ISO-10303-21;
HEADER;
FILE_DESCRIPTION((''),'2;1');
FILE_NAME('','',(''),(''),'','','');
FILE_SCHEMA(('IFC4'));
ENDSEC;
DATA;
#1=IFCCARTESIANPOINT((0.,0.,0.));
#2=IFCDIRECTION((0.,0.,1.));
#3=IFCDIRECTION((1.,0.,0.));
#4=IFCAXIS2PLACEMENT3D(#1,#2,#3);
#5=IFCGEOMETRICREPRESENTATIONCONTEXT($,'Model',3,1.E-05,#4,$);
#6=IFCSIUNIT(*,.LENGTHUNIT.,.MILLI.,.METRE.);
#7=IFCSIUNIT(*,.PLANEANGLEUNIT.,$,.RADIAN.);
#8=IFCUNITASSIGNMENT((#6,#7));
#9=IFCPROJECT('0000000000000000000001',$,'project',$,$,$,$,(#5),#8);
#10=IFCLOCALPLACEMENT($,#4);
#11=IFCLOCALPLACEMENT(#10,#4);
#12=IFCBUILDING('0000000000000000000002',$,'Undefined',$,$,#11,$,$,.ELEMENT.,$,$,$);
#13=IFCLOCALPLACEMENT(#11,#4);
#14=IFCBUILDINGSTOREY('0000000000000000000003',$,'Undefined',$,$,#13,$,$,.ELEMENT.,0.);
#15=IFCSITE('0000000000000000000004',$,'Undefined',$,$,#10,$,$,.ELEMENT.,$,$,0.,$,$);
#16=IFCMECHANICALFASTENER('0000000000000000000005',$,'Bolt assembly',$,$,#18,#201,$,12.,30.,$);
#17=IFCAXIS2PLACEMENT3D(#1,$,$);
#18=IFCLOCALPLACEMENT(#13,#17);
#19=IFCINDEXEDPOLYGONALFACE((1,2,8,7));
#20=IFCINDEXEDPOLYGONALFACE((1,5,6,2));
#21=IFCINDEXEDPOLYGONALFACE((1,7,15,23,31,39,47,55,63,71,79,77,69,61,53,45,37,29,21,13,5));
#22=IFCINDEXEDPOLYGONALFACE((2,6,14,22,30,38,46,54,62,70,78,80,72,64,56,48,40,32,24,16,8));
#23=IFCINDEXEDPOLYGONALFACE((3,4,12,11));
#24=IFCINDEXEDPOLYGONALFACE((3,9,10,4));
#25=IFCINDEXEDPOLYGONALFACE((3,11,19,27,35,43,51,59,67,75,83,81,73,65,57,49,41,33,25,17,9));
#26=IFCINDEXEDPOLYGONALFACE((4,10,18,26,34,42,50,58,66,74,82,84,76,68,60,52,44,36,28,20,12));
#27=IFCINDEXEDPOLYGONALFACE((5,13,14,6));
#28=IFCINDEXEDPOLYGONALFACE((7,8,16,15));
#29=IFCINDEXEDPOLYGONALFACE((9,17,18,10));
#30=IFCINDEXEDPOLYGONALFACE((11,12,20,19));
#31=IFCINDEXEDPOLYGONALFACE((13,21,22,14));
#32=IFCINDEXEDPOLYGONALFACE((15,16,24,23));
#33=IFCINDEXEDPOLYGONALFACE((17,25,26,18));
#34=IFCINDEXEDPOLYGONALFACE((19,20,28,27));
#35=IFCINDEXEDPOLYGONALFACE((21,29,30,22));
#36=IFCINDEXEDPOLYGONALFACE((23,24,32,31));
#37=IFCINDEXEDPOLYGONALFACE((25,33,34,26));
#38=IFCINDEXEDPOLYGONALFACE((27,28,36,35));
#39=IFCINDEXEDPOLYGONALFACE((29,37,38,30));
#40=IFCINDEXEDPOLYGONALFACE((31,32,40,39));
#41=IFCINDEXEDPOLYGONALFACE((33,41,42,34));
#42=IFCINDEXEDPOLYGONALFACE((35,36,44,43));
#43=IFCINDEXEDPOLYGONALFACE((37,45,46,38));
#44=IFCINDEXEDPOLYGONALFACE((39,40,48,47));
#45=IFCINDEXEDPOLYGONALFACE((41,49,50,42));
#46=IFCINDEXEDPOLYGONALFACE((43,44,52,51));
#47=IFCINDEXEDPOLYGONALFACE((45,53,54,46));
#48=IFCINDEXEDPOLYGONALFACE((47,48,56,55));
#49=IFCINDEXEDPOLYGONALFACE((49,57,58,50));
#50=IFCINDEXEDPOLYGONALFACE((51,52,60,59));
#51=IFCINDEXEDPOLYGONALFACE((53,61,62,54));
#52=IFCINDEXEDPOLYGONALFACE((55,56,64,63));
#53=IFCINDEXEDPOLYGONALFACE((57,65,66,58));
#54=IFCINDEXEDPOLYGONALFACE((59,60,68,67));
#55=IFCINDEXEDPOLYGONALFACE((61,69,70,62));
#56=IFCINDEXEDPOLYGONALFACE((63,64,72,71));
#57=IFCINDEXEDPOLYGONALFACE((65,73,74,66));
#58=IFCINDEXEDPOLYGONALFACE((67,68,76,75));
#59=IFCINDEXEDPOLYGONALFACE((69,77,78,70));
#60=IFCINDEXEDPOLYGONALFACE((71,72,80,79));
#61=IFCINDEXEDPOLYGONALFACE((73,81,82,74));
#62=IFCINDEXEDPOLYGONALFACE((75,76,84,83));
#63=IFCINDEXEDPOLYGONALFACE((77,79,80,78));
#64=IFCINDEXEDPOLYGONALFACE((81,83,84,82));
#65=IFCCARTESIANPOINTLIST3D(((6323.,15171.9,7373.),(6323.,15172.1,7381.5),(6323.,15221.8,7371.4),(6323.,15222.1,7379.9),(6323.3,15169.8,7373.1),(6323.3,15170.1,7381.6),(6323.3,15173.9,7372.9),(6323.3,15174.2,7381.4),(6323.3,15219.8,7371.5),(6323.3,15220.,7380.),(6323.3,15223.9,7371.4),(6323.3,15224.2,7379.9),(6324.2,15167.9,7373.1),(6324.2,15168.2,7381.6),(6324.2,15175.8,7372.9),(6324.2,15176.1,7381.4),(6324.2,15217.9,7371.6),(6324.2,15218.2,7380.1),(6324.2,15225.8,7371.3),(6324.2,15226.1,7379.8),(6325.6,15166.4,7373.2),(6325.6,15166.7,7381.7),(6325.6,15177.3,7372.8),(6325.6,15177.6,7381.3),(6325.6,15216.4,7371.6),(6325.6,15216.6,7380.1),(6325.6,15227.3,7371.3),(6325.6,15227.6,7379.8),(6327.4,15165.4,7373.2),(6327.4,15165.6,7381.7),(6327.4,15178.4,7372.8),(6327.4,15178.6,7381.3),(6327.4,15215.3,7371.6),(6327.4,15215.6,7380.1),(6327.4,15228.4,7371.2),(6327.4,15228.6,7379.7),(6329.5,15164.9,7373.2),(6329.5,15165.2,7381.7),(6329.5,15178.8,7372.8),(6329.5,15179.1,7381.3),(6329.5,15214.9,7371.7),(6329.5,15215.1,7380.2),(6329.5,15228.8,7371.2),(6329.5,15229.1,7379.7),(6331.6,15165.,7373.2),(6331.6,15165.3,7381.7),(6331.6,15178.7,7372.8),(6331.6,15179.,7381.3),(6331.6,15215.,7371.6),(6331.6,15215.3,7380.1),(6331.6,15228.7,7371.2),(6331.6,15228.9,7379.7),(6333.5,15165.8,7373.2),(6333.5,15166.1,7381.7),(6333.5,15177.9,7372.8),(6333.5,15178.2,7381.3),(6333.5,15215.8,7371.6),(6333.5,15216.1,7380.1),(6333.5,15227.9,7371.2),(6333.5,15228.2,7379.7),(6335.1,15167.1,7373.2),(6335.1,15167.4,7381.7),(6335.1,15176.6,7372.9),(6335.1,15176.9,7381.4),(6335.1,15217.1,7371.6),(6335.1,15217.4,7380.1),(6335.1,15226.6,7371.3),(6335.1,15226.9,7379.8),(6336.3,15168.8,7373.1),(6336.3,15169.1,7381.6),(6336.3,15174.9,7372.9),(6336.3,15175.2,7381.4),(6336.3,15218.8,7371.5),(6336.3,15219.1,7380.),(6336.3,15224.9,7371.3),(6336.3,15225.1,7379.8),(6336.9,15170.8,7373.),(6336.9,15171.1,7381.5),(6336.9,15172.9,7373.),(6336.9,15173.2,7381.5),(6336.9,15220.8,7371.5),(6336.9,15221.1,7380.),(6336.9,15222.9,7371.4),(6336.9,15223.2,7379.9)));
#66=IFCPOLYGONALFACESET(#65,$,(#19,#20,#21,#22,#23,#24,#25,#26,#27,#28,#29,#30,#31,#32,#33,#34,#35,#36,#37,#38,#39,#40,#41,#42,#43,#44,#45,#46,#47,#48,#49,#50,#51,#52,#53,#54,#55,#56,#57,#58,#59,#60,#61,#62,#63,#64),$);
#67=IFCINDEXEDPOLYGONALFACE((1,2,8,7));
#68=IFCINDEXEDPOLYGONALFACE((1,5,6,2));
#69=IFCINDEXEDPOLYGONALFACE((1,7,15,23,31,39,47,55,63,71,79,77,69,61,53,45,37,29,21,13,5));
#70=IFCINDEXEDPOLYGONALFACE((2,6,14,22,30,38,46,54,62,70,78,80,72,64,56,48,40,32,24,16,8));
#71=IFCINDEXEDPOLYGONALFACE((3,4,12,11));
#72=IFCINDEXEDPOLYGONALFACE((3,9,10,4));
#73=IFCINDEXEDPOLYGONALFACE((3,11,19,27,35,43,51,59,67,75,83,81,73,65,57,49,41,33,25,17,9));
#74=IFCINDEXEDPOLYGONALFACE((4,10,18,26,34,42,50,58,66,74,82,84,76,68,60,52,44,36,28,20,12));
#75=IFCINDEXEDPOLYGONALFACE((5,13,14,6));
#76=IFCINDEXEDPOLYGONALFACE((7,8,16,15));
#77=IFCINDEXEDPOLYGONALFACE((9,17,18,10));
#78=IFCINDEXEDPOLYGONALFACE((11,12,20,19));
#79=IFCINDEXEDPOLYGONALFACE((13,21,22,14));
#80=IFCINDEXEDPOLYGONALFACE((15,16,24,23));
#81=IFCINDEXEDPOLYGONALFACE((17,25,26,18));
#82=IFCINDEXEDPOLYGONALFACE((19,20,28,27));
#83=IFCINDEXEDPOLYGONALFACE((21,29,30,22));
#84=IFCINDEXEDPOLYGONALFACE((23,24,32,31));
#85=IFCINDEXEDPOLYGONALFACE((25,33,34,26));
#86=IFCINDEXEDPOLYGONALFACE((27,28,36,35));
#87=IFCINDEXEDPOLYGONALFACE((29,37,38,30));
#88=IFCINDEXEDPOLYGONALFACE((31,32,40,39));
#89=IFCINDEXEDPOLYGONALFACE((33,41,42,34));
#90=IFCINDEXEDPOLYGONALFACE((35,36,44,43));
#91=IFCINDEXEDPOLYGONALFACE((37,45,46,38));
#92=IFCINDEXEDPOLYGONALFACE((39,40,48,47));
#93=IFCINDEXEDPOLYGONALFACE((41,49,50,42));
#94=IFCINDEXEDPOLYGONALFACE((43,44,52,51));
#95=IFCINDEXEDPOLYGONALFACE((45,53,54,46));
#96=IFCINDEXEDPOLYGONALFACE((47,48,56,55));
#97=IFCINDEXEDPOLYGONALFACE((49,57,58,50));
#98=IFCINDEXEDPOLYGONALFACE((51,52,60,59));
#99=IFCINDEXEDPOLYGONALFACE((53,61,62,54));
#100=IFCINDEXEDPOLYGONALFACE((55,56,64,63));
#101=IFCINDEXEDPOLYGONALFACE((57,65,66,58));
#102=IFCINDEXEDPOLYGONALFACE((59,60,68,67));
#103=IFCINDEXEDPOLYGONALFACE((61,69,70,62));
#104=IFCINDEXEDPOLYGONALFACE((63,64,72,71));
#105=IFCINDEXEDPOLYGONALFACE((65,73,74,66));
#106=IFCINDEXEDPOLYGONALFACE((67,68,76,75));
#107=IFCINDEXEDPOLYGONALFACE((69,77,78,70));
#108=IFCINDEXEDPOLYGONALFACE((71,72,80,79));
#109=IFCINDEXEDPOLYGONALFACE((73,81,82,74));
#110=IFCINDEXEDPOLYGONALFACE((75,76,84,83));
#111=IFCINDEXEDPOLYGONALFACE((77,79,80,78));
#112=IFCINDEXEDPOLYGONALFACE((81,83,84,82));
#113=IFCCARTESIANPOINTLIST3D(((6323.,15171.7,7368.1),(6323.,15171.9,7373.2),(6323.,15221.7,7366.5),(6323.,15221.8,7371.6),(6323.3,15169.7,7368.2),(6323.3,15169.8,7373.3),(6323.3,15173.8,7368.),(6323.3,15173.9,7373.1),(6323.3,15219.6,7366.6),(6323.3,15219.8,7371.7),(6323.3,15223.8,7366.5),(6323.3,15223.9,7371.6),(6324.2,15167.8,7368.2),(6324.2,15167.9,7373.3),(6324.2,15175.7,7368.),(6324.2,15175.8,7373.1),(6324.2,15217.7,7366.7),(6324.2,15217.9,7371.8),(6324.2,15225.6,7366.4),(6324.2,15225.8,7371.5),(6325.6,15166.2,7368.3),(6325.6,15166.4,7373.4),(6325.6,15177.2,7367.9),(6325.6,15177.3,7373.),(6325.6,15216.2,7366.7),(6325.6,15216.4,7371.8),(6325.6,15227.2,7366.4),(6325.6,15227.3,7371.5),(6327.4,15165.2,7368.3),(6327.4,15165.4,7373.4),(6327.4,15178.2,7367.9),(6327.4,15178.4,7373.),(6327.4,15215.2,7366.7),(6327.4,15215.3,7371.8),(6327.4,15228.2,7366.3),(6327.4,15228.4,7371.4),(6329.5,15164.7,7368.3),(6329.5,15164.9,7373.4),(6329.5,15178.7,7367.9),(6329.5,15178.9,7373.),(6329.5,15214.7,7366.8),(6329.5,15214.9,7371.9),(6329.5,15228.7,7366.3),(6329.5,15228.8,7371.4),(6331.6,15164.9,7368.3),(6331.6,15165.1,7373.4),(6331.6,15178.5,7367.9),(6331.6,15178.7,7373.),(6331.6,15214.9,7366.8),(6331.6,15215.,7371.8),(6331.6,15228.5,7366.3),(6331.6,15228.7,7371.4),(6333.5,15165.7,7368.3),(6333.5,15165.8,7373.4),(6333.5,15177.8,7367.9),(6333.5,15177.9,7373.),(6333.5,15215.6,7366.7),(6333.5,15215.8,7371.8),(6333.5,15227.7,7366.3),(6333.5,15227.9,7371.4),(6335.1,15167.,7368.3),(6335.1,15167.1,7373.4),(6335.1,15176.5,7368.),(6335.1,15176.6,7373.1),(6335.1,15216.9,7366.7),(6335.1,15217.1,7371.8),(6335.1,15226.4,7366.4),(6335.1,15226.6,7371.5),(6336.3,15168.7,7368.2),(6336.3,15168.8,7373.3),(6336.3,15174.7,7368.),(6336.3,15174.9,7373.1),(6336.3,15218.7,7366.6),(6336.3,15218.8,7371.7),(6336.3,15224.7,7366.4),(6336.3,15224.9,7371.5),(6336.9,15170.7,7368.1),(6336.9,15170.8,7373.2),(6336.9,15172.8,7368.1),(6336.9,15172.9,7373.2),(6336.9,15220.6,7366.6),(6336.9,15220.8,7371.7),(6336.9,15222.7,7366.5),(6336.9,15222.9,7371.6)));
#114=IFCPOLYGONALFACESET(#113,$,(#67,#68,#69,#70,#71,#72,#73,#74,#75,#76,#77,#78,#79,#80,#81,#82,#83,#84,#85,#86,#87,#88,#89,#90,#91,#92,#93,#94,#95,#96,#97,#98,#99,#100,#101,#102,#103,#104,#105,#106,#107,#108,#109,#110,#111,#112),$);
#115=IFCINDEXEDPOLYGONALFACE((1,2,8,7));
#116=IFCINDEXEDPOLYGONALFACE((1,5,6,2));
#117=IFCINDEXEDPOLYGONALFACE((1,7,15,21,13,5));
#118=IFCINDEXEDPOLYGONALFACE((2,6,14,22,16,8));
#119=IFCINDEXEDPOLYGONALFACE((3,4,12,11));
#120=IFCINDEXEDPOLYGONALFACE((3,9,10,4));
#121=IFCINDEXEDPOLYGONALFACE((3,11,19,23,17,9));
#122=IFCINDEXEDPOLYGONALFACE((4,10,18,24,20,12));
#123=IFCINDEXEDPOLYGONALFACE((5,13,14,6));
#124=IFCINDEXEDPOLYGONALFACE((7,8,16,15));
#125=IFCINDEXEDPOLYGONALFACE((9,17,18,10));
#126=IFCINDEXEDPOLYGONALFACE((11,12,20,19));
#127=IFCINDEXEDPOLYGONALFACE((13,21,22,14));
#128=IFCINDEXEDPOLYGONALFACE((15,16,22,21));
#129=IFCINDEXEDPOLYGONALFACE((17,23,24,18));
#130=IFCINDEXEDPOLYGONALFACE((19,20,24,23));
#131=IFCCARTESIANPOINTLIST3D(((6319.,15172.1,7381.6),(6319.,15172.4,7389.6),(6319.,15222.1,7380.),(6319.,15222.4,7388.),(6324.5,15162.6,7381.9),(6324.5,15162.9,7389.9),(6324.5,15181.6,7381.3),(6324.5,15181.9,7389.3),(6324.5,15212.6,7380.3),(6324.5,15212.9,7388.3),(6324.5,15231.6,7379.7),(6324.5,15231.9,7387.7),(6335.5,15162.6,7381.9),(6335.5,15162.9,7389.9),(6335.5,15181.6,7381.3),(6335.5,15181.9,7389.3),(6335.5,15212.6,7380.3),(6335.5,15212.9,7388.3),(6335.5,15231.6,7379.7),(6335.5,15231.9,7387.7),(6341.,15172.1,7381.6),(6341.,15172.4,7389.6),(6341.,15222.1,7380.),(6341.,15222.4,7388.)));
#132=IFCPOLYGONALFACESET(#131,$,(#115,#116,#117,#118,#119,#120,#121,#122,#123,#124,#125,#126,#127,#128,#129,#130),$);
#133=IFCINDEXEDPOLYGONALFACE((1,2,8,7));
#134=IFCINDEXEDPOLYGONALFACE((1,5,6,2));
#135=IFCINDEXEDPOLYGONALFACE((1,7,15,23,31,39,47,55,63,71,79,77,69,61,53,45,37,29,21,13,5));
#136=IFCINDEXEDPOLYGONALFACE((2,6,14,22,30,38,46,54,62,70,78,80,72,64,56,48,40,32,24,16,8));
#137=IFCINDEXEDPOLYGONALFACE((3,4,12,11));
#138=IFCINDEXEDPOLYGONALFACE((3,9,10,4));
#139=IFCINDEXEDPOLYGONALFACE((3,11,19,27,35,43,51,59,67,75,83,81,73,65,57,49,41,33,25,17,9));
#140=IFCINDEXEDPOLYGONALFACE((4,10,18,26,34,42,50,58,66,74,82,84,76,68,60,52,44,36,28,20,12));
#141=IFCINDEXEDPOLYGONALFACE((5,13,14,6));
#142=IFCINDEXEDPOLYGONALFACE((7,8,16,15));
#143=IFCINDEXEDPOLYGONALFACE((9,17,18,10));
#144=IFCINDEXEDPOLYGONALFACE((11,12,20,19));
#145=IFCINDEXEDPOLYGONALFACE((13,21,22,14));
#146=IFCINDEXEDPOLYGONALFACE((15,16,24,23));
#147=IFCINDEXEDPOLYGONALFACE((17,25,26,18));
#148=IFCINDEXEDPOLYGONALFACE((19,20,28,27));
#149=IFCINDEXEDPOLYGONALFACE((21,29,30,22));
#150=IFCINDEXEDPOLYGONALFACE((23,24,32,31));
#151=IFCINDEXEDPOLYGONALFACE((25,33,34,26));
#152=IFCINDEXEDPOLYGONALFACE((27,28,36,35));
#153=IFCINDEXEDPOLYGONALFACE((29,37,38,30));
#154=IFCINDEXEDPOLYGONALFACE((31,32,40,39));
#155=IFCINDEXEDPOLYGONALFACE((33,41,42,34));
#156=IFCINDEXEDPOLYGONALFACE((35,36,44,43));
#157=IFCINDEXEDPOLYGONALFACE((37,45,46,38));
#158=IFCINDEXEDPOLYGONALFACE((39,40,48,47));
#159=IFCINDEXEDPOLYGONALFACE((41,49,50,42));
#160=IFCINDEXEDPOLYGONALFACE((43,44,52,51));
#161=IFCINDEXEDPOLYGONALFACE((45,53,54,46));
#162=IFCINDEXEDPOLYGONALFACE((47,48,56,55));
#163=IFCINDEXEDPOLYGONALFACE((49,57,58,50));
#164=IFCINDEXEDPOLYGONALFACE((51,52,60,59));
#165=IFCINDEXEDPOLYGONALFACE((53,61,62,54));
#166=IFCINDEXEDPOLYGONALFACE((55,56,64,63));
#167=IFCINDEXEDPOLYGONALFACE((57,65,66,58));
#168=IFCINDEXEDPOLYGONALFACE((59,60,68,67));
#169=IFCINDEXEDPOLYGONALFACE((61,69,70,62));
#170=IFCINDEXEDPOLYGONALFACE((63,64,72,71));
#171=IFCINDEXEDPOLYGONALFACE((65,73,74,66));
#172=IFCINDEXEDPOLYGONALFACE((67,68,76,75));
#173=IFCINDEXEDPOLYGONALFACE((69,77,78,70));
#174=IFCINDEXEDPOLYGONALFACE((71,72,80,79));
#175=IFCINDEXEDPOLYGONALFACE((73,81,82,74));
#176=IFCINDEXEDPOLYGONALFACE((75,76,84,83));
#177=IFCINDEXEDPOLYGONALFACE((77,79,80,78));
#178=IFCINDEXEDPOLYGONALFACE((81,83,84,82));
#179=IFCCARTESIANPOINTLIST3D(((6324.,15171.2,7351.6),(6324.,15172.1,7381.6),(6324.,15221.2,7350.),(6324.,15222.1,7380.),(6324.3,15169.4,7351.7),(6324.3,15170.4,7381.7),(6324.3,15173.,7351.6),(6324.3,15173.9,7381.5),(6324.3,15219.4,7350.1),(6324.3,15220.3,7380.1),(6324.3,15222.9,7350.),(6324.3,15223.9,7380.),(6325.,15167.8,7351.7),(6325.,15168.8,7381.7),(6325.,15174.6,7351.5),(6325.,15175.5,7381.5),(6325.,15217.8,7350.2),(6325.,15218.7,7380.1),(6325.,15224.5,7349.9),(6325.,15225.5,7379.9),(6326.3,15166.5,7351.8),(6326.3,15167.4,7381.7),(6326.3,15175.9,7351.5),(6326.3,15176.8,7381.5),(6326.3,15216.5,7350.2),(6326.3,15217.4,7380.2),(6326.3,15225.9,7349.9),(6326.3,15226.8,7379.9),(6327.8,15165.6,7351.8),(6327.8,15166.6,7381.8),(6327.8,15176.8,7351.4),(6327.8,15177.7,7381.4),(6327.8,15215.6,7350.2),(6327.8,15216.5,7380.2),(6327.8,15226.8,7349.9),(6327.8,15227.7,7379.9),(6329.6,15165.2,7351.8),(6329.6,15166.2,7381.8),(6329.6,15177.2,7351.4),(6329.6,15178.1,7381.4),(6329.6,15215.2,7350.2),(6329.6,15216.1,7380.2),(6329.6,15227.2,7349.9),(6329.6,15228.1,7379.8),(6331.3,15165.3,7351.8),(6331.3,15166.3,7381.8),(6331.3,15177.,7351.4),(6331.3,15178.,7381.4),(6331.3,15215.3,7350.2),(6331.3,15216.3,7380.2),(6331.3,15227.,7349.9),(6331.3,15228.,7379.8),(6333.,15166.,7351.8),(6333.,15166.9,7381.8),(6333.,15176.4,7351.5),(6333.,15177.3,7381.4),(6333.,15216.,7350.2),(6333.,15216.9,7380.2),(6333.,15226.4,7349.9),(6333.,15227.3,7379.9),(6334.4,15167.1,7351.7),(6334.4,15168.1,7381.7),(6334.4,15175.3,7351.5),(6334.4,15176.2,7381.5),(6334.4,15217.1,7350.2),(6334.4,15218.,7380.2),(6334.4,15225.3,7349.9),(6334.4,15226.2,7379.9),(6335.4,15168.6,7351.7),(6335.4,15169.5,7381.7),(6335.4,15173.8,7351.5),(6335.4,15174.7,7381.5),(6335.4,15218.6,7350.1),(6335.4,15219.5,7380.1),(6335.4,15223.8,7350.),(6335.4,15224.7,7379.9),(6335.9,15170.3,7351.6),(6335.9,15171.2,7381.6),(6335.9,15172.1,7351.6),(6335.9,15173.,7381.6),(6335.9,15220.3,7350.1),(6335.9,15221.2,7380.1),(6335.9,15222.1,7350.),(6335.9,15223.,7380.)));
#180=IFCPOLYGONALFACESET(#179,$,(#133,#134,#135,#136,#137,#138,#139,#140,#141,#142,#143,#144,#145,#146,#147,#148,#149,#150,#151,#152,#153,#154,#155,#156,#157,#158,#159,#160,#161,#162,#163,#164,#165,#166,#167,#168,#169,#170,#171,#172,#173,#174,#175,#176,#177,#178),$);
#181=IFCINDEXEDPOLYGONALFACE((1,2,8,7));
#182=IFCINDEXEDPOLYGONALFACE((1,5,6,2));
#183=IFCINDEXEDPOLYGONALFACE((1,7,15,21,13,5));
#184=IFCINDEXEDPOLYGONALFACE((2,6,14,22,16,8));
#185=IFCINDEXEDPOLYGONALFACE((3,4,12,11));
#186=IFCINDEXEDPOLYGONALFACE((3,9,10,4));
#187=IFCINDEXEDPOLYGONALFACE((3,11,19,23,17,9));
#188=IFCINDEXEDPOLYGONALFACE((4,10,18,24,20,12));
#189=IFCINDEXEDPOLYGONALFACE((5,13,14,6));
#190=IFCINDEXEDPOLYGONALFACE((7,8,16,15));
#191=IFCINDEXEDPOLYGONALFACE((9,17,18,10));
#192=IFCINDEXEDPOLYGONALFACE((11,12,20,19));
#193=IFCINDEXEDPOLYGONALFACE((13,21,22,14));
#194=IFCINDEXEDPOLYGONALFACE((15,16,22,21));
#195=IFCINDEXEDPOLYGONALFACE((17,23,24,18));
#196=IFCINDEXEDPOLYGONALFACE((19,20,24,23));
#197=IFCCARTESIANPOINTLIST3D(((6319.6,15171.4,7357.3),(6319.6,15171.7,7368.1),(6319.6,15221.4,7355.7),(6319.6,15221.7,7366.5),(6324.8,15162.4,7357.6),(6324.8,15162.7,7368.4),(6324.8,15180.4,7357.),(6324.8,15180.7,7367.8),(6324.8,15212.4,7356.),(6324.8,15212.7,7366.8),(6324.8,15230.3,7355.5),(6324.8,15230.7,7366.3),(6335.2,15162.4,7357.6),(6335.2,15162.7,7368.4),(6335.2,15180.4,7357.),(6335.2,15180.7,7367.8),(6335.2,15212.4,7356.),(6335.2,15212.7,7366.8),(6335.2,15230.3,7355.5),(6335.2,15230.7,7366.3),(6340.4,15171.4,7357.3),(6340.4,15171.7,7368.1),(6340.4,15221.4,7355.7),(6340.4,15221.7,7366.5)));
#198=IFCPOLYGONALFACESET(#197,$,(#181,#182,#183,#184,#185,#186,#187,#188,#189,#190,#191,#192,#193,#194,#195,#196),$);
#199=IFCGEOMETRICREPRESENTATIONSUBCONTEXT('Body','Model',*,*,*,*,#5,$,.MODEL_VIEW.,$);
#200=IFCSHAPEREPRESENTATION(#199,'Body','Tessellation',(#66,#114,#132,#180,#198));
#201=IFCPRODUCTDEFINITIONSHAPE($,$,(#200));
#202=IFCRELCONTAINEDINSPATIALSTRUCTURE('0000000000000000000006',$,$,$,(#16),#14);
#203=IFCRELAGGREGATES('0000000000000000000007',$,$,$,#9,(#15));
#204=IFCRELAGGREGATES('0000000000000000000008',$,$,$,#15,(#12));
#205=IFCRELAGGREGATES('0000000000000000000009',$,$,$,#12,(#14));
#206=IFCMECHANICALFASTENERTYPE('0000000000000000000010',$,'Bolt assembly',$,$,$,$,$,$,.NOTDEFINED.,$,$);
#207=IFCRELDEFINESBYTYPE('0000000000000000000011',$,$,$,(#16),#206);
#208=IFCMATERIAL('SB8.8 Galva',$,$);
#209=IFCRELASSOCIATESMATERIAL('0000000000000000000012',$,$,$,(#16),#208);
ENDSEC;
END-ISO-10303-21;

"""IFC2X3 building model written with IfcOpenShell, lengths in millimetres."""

from ifc_helpers import new_model, si_unit, frame, origin_with_axes, origin_2d_with_axis, place, context, subcontext, project, spatial, polyline, circle, outline, extrude, source, transform, mapped, material, type_object, element, save


model = new_model("IFC2X3")

# Units and contexts
model_context = context("Model", 3, precision=1e-05, world=origin_with_axes())
body_context = subcontext(model_context, "Body", "Model", "MODEL_VIEW")
ifc_project = project(units=[si_unit("LENGTHUNIT", "METRE", prefix="MILLI"), si_unit("PLANEANGLEUNIT", "RADIAN")], contexts=[model_context])

# Site, building, storey
site_placement = place(None, origin_with_axes())
site = spatial("IfcSite", under=ifc_project, at=site_placement, Name="Undefined", CompositionType="ELEMENT", RefElevation=0.0)
building_placement = place(site_placement, origin_with_axes())
building = spatial("IfcBuilding", under=site, at=building_placement, Name="Undefined", CompositionType="ELEMENT")
storey_placement = place(building_placement, origin_with_axes())
storey = spatial("IfcBuildingStorey", under=building, at=storey_placement, Name="Undefined", CompositionType="ELEMENT", Elevation=0.0)

# Mechanical fastener
mechanical_fastener_type = type_object("IfcMechanicalFastenerType", Name="Bolt assembly")
ifc_material_1 = material(Name="SB8.8 Galva")
shared_shape_1 = source(origin_with_axes(), body_context, "Body", "SweptSolid", [
    extrude(circle(Radius=7.0, at=origin_2d_with_axis()), frame((0.0, -8.4, 0.0), z_axis=(0.0, 1.0, 0.0), x_axis=(1.0, 0.0, 0.0)), (0.0, 0.0, 1.0), 8.5),
    extrude(circle(Radius=7.0, at=origin_2d_with_axis()), frame((0.0, -0.1, 0.0), z_axis=(0.0, 1.0, 0.0), x_axis=(1.0, 0.0, 0.0)), (0.0, 0.0, 1.0), 5.1),
    extrude(outline(polyline([(11.0, 0.0), (5.5, 9.5), (-5.5, 9.5), (-11.0, 0.0), (-5.5, -9.5), (5.5, -9.5), (11.0, 0.0)])), frame((0.0, -16.5, 0.0), z_axis=(0.0, 1.0, 0.0), x_axis=(1.0, 0.0, 0.0)), (0.0, 0.0, 1.0), 8.0),
    extrude(circle(Radius=6.0, at=origin_2d_with_axis()), frame((0.0, -8.5, 0.0), z_axis=(0.0, 1.0, 0.0), x_axis=(1.0, 0.0, 0.0)), (0.0, 0.0, 1.0), 30.0),
    extrude(outline(polyline([(10.4, 0.0), (5.2, 9.0), (-5.2, 9.0), (-10.4, 0.0), (-5.2, -9.0), (5.2, -9.0), (10.4, 0.0)])), frame((0.0, 5.0, 0.0), z_axis=(0.0, 1.0, 0.0), x_axis=(1.0, 0.0, 0.0)), (0.0, 0.0, 1.0), 10.8),
])
for number, where, z_axis, x_axis, name in (
    (1, (6330.0, 15196.9, 7372.3), (0.0, -0.999507, 0.031411), (-1.0, 0.0, 0.0), "Bolt assembly"),
):
    element("IfcMechanicalFastener", number, at=place(storey_placement, frame(where, z_axis=z_axis, x_axis=x_axis)), inside=storey, type_object=mechanical_fastener_type, material=ifc_material_1, Name=name, NominalDiameter=12.0, NominalLength=30.0, context=body_context, shape_type="MappedRepresentation", body=[
        mapped(shared_shape_1, transform((0.0, 0.0, -25.0))),
        mapped(shared_shape_1, transform((0.0, 0.0, 25.0))),
    ])

save(model, "model.ifc")
